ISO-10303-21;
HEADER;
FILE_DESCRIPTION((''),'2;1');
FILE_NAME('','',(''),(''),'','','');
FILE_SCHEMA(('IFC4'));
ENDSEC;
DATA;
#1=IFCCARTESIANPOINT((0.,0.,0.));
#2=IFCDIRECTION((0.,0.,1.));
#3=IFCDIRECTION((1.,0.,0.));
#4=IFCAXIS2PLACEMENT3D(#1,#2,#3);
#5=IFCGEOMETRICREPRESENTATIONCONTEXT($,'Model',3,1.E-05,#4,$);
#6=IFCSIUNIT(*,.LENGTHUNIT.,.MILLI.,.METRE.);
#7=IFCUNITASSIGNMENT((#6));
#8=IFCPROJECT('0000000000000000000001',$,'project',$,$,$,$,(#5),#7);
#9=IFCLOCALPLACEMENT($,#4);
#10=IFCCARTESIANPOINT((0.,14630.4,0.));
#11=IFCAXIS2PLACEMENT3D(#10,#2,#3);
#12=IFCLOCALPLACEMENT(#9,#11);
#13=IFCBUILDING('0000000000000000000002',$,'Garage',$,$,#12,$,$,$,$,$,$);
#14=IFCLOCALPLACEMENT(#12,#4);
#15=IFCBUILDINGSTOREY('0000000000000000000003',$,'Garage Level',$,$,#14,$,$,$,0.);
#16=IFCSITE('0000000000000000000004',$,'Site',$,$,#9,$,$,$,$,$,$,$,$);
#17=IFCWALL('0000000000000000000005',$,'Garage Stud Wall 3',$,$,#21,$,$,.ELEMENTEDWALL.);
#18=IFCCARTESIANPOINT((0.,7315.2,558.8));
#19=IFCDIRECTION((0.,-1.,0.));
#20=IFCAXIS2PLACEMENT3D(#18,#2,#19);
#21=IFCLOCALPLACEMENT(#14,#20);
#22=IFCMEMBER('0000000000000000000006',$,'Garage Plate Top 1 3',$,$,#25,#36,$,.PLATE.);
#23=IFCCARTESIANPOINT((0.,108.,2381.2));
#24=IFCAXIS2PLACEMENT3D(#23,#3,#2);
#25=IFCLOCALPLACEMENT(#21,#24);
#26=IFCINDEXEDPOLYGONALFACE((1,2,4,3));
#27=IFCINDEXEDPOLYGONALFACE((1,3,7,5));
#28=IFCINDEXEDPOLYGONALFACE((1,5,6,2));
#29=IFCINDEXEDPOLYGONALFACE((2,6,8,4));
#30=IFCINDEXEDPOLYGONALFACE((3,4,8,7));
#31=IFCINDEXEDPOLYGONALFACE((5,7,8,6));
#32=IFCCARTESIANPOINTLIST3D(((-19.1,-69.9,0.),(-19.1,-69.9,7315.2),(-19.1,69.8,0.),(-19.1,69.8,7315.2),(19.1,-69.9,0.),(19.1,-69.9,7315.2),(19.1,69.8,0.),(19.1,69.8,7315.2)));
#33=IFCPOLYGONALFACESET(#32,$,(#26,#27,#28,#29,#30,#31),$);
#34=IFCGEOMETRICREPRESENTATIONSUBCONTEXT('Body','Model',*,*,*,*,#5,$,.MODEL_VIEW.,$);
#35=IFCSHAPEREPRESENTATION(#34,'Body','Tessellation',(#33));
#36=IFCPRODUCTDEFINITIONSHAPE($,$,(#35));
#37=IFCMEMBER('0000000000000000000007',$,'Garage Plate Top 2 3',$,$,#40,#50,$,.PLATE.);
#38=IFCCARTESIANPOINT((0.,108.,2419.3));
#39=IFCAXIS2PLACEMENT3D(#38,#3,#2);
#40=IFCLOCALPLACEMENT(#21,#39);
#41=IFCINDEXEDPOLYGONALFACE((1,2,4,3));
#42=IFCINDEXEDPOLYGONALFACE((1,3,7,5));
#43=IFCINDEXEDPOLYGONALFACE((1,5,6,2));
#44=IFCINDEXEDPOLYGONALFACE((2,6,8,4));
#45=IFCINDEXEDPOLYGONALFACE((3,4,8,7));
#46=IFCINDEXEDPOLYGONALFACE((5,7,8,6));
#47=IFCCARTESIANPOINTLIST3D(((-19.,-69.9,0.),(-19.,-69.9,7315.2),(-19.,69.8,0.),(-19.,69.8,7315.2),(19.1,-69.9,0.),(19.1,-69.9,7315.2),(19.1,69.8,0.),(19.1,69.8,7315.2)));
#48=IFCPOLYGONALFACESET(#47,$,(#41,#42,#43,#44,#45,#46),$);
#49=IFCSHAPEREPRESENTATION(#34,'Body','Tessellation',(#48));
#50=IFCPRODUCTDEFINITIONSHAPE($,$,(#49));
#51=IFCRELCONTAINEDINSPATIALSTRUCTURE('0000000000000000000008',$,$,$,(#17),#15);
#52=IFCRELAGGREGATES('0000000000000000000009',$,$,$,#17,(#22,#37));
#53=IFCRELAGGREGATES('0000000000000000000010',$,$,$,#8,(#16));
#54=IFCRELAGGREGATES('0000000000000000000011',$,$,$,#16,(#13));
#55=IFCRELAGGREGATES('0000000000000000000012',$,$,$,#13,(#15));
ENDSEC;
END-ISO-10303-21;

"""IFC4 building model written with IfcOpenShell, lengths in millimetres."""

from ifc_helpers import new_model, si_unit, frame, origin_with_axes, origin_2d, place, context, subcontext, project, spatial, rectangle, extrude, element, aggregate, save


model = new_model("IFC4")

# Units and contexts
model_context = context("Model", 3, precision=1e-05, world=origin_with_axes())
body_context = subcontext(model_context, "Body", "Model", "MODEL_VIEW")
ifc_project = project(units=[si_unit("LENGTHUNIT", "METRE", prefix="MILLI")], contexts=[model_context])

# Site, building, storey
site_placement = place(None, origin_with_axes())
site = spatial("IfcSite", under=ifc_project, at=site_placement, Name="Site")
building_placement = place(site_placement, frame((0.0, 14630.4, 0.0), z_axis=(0.0, 0.0, 1.0), x_axis=(1.0, 0.0, 0.0)))
building = spatial("IfcBuilding", under=site, at=building_placement, Name="Garage")
storey_placement = place(building_placement, origin_with_axes())
storey = spatial("IfcBuildingStorey", under=building, at=storey_placement, Name="Garage Level", Elevation=0.0)

# Wall, members
wall_1_placement = place(storey_placement, frame((0.0, 7315.2, 558.8), z_axis=(0.0, 0.0, 1.0), x_axis=(0.0, -1.0, 0.0)))
wall_1 = element("IfcWall", 1, at=wall_1_placement, inside=storey, Name="Garage Stud Wall 3", PredefinedType="ELEMENTEDWALL")
member_1_placement = place(wall_1_placement, frame((0.0, 108.0, 2381.2), z_axis=(1.0, 0.0, 0.0), x_axis=(0.0, 0.0, 1.0)))
member_1 = element("IfcMember", 2, at=member_1_placement, Name="Garage Plate Top 1 3", PredefinedType="PLATE", context=body_context, shape_type="SweptSolid", body=[
    extrude(rectangle(XDim=38.1, YDim=139.7, at=origin_2d()), origin_with_axes(), (0.0, 0.0, 1.0), 7315.2),
])
member_2_placement = place(wall_1_placement, frame((0.0, 108.0, 2419.3), z_axis=(1.0, 0.0, 0.0), x_axis=(0.0, 0.0, 1.0)))
member_2 = element("IfcMember", 3, at=member_2_placement, Name="Garage Plate Top 2 3", PredefinedType="PLATE", context=body_context, shape_type="SweptSolid", body=[
    extrude(rectangle(XDim=38.1, YDim=139.7, at=origin_2d()), origin_with_axes(), (0.0, 0.0, 1.0), 7315.2),
])
aggregate(wall_1, [member_1, member_2])

save(model, "model.ifc")
